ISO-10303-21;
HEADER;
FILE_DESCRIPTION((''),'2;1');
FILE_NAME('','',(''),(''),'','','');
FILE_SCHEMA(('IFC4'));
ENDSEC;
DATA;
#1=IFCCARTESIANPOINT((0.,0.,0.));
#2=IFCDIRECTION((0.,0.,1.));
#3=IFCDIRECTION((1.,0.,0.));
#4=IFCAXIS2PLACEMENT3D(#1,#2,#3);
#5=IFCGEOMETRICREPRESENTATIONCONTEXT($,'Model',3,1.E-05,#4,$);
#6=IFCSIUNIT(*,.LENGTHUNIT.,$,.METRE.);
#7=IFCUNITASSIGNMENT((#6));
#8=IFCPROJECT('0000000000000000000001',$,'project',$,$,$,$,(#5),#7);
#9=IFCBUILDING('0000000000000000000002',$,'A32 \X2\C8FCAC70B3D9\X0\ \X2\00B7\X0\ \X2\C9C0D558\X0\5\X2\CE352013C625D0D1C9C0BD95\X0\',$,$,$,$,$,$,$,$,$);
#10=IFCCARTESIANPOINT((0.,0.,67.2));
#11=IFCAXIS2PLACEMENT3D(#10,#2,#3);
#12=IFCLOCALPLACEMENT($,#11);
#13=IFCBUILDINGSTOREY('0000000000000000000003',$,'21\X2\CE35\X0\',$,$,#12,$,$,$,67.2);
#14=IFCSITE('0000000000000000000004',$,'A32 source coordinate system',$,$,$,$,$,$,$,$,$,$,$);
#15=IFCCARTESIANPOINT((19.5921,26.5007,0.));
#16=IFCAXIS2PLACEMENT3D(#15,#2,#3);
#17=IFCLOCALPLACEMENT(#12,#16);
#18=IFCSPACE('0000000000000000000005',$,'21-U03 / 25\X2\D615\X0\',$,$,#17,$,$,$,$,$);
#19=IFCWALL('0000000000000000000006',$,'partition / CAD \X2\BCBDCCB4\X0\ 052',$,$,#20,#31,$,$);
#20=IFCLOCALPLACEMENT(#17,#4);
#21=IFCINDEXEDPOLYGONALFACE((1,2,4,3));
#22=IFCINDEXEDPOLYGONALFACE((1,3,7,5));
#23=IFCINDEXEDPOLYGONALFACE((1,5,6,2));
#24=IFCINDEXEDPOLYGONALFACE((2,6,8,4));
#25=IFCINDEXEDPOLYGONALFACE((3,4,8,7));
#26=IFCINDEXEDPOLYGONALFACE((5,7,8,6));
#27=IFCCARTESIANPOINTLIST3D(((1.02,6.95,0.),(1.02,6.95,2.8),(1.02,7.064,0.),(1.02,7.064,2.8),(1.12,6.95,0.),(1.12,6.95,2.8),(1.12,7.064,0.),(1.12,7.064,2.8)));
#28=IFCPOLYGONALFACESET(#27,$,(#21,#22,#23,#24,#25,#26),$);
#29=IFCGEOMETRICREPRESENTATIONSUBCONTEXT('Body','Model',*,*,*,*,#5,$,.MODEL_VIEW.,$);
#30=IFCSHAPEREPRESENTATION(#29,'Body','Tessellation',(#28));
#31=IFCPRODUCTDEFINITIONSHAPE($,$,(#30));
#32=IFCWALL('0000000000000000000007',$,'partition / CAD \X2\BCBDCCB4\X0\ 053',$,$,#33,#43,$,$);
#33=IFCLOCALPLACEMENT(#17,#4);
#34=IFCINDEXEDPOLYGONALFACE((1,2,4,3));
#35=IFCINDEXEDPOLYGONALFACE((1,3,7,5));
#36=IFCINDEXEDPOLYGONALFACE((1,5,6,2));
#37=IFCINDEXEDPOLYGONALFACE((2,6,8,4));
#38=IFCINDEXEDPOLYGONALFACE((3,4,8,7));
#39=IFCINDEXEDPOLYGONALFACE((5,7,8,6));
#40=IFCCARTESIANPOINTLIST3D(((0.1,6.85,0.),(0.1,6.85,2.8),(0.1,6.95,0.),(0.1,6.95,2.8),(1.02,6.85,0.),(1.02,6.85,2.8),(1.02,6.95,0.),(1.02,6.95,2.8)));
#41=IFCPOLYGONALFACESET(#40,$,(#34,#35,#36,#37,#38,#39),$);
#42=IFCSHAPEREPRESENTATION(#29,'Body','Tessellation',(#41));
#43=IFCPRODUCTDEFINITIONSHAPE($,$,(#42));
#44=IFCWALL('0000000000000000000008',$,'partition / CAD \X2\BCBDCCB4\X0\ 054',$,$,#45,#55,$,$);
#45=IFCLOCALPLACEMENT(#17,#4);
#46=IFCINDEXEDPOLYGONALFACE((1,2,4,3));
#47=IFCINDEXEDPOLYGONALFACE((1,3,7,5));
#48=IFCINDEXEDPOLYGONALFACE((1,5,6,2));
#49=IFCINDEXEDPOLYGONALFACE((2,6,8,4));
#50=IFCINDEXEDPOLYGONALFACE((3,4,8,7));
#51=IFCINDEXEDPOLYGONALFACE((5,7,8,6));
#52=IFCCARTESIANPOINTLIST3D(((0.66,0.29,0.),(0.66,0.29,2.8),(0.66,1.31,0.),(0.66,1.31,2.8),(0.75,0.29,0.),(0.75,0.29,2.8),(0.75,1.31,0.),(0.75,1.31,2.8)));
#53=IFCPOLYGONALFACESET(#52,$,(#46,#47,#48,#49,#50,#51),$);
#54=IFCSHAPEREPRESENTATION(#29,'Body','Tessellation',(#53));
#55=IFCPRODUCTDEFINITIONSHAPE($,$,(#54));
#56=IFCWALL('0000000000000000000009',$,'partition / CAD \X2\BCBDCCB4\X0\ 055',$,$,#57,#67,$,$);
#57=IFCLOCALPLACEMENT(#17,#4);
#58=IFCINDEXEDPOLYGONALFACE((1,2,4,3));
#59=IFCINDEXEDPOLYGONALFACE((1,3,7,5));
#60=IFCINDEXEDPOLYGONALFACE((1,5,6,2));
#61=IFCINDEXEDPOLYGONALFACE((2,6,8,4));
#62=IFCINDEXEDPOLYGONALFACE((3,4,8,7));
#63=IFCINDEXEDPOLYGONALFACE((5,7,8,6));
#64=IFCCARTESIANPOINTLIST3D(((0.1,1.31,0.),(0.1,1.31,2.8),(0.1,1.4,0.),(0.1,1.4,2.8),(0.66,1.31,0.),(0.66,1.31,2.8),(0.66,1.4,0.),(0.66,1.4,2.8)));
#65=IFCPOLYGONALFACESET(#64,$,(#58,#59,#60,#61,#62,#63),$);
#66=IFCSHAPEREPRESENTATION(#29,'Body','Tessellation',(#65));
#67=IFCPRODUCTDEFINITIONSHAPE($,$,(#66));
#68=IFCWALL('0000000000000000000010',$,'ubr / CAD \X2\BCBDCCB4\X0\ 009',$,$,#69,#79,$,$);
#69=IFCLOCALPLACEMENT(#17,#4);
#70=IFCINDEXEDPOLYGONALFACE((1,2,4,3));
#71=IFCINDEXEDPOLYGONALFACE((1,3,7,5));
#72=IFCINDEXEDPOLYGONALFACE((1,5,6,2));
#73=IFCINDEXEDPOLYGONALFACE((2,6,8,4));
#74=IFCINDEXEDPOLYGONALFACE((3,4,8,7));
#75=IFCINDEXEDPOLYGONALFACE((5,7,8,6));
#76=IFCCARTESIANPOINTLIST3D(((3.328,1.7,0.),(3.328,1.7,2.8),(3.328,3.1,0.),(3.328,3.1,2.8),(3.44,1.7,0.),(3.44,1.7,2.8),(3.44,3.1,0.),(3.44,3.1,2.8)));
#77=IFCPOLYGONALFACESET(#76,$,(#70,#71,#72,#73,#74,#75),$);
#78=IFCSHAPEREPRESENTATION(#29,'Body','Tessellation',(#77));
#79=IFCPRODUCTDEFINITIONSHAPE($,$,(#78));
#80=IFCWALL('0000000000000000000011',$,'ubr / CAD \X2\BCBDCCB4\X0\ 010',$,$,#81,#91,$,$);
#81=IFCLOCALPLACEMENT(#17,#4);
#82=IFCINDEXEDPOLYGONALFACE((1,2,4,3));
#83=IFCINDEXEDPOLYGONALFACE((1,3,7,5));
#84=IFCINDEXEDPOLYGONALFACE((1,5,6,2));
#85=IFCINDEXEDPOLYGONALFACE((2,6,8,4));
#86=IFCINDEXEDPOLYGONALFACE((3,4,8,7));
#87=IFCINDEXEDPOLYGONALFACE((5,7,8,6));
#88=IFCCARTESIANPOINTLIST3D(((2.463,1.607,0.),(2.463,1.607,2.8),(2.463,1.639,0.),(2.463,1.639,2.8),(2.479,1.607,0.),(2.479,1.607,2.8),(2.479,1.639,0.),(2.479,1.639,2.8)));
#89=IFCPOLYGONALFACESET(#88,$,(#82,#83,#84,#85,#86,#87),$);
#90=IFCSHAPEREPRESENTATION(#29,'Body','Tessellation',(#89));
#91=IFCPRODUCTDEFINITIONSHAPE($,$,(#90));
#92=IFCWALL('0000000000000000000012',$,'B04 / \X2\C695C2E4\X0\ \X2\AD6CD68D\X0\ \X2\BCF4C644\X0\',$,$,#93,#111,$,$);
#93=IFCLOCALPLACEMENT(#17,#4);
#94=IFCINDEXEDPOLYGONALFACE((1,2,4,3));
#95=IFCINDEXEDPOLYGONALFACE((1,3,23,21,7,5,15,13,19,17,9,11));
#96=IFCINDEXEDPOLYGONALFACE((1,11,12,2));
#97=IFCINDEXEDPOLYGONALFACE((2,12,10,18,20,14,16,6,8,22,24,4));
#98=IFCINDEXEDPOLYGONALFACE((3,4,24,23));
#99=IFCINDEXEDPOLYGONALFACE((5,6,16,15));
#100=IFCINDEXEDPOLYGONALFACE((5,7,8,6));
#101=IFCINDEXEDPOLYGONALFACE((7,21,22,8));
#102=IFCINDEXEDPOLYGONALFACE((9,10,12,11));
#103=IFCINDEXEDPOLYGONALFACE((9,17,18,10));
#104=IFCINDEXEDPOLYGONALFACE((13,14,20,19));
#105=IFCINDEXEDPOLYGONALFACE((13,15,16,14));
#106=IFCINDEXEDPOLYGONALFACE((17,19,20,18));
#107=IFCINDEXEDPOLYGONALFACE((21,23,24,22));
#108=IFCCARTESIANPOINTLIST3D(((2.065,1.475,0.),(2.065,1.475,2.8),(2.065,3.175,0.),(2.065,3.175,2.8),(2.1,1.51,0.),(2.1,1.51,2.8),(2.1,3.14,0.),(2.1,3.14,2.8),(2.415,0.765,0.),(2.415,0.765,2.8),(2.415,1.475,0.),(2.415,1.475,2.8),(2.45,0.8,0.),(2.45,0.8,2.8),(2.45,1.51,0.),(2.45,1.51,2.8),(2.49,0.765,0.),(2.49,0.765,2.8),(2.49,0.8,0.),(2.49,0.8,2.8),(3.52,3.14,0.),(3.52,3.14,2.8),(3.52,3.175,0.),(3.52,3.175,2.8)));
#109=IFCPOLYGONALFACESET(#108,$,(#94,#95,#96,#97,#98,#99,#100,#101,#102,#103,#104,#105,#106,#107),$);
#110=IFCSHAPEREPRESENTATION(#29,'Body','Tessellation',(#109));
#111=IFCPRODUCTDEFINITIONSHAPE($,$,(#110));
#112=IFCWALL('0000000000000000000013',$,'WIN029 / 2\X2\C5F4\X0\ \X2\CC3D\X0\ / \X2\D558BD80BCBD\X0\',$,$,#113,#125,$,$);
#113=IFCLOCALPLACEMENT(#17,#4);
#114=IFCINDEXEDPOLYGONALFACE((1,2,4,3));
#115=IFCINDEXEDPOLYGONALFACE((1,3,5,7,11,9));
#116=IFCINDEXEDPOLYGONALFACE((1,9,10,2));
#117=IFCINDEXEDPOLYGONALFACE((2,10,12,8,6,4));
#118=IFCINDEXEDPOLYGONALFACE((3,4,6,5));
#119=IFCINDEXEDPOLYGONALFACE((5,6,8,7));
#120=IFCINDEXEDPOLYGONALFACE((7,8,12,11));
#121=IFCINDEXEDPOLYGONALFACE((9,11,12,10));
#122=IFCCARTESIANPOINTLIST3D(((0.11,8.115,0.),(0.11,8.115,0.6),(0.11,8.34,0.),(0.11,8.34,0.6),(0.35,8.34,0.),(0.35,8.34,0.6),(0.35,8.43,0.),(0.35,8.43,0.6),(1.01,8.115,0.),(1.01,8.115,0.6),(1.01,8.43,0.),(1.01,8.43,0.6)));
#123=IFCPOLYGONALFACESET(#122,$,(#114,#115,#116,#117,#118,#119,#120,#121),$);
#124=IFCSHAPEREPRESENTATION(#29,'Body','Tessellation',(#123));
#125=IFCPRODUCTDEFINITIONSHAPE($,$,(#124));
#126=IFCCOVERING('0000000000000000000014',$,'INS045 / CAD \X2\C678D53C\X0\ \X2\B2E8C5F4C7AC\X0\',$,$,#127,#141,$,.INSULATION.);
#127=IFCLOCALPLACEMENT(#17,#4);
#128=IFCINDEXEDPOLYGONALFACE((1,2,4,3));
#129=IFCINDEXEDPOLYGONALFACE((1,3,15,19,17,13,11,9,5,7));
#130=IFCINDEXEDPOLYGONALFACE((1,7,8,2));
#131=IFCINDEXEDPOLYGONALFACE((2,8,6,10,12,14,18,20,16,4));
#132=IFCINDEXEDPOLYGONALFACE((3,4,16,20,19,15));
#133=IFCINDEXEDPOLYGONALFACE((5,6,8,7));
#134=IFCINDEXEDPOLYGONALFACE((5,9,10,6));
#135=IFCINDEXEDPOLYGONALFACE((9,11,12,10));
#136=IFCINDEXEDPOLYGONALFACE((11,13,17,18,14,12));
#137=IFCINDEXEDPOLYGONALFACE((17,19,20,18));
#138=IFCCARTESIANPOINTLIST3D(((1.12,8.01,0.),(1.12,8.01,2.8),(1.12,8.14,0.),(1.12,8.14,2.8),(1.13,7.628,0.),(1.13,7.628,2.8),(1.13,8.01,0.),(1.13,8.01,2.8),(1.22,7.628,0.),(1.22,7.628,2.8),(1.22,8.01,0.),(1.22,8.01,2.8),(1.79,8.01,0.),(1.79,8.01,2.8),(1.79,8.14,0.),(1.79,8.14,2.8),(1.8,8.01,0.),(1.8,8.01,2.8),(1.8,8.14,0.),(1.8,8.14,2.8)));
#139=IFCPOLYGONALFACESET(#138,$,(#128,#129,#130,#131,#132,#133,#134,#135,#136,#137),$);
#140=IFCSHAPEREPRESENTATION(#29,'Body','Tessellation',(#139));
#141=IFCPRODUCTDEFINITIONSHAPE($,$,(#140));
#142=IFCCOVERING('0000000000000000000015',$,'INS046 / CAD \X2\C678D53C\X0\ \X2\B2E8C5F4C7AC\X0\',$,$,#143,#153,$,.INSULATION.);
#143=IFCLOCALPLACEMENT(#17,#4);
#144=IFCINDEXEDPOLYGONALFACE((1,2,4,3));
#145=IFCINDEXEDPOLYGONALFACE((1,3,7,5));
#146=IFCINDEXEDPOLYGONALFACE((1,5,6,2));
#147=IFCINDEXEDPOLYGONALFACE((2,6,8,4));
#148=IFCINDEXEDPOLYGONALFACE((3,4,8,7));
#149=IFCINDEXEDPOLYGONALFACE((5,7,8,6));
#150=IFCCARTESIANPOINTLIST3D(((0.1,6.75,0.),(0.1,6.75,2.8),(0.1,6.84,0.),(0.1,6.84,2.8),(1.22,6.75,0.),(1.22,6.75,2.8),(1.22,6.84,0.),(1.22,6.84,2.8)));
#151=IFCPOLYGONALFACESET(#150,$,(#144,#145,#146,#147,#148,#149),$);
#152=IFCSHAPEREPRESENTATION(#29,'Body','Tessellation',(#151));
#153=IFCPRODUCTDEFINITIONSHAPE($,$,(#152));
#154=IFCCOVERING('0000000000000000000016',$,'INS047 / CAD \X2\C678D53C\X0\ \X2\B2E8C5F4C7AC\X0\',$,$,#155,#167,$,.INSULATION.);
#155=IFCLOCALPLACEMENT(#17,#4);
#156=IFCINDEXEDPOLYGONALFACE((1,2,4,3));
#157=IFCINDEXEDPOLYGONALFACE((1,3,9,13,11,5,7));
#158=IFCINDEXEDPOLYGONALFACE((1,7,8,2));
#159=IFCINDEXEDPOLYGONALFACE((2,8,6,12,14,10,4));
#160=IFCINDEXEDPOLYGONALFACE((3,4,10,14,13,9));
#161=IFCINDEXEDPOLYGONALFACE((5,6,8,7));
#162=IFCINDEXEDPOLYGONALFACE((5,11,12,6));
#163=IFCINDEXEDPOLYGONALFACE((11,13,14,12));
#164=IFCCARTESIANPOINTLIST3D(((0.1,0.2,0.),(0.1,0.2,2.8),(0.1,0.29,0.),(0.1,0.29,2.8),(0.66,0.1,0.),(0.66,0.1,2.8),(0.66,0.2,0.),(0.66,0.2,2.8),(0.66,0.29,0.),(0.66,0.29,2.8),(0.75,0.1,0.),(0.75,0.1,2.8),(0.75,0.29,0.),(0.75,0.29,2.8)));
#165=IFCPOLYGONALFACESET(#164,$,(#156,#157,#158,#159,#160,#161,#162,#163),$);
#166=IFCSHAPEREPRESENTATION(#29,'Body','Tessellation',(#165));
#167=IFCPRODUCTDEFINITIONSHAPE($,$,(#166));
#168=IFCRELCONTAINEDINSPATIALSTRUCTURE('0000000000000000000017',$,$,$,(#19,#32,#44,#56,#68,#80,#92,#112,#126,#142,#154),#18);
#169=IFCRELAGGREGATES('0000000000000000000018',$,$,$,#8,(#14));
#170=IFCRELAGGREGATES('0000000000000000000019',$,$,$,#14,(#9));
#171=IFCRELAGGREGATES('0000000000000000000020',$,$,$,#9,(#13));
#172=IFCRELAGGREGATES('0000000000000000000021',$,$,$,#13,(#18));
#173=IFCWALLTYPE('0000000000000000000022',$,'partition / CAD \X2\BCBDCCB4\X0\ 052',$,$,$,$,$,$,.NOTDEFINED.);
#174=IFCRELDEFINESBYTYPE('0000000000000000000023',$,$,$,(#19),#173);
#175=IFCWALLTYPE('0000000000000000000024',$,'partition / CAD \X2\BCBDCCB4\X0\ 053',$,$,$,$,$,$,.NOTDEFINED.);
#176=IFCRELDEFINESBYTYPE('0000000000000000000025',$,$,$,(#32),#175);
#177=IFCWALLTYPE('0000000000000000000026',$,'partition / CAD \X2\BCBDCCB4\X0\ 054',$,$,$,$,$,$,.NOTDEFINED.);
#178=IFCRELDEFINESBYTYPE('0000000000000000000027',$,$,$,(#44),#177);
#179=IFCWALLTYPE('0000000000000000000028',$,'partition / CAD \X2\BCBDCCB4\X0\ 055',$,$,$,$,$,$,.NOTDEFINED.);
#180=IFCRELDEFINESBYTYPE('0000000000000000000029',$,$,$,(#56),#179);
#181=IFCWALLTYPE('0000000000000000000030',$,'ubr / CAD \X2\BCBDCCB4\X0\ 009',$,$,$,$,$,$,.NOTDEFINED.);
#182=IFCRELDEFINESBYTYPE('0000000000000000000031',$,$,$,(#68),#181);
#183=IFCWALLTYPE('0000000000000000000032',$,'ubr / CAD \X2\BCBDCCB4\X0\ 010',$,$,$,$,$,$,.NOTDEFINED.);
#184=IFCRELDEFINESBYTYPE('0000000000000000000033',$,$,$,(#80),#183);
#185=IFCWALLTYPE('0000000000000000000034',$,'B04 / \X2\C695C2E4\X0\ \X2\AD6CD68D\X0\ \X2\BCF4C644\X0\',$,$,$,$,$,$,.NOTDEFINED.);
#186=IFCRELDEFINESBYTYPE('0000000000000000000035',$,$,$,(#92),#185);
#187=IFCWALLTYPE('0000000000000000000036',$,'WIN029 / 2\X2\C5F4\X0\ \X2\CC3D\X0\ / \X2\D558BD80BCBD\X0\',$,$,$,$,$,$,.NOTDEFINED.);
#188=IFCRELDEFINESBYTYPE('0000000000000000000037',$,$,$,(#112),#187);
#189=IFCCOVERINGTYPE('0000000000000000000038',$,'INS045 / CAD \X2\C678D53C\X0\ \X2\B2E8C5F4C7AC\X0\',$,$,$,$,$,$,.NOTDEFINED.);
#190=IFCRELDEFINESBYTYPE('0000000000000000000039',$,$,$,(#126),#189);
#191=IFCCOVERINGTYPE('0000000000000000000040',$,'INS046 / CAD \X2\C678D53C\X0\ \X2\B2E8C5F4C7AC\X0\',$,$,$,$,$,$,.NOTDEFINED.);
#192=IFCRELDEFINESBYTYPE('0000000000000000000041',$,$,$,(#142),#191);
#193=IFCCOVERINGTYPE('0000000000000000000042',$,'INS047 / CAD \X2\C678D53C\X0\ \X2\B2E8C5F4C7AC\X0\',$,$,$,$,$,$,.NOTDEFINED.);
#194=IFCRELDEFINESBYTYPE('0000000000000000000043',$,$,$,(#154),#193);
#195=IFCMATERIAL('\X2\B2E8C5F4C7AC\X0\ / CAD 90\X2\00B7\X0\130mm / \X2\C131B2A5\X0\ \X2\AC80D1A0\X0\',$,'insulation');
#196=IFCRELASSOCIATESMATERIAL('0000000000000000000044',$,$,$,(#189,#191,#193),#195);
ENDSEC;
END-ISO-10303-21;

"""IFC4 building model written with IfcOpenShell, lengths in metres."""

from ifc_helpers import new_model, si_unit, frame, origin, origin_with_axes, place, context, subcontext, project, spatial, polyline, outline, extrude, source, transform, mapped, material, type_object, type_shapes, element, save


model = new_model("IFC4")

# Units and contexts
model_context = context("Model", 3, precision=1e-05, world=origin_with_axes())
body_context = subcontext(model_context, "Body", "Model", "MODEL_VIEW")
ifc_project = project(units=[si_unit("LENGTHUNIT", "METRE")], contexts=[model_context])

# Site, building, storey, space
storey_placement = place(None, frame((0.0, 0.0, 67.2), z_axis=(0.0, 0.0, 1.0), x_axis=(1.0, 0.0, 0.0)))
space_placement = place(storey_placement, frame((19.5921, 26.5007, 0.0), z_axis=(0.0, 0.0, 1.0), x_axis=(1.0, 0.0, 0.0)))
site = spatial("IfcSite", under=ifc_project, Name="A32 source coordinate system")
building = spatial("IfcBuilding", under=site, Name="A32 주거동 · 지하5층–옥탑지붕")
storey = spatial("IfcBuildingStorey", under=building, at=storey_placement, Name="21층", Elevation=67.2)
space = spatial("IfcSpace", under=storey, at=space_placement, Name="21-U03 / 25형")

# Walls
wall_type_1 = type_object("IfcWallType", Name="partition / CAD 벽체 052", PredefinedType="NOTDEFINED")
shared_shape_1 = source(origin(), body_context, "Body", "SweptSolid", [
    extrude(outline(polyline([(1.12, 6.95), (1.02, 6.95), (1.02, 7.064), (1.12, 7.064), (1.12, 6.95)])), origin(), (0.0, 0.0, 1.0), 2.8),
])
type_shapes(wall_type_1, [shared_shape_1])
wall_1_placement = place(space_placement, origin_with_axes())
element("IfcWall", 1, at=wall_1_placement, inside=space, type_object=wall_type_1, Name="partition / CAD 벽체 052", context=body_context, shape_type="MappedRepresentation", body=[
    mapped(shared_shape_1, transform((0.0, 0.0, 0.0), scale=1.0)),
])
wall_type_2 = type_object("IfcWallType", Name="partition / CAD 벽체 053", PredefinedType="NOTDEFINED")
shared_shape_2 = source(origin(), body_context, "Body", "SweptSolid", [
    extrude(outline(polyline([(1.02, 6.95), (1.02, 6.85), (0.1, 6.85), (0.1, 6.95), (1.02, 6.95)])), origin(), (0.0, 0.0, 1.0), 2.8),
])
type_shapes(wall_type_2, [shared_shape_2])
wall_2_placement = place(space_placement, origin_with_axes())
element("IfcWall", 2, at=wall_2_placement, inside=space, type_object=wall_type_2, Name="partition / CAD 벽체 053", context=body_context, shape_type="MappedRepresentation", body=[
    mapped(shared_shape_2, transform((0.0, 0.0, 0.0), scale=1.0)),
])
wall_type_3 = type_object("IfcWallType", Name="partition / CAD 벽체 054", PredefinedType="NOTDEFINED")
shared_shape_3 = source(origin(), body_context, "Body", "SweptSolid", [
    extrude(outline(polyline([(0.75, 0.29), (0.66, 0.29), (0.66, 1.31), (0.75, 1.31), (0.75, 0.29)])), origin(), (0.0, 0.0, 1.0), 2.8),
])
type_shapes(wall_type_3, [shared_shape_3])
wall_3_placement = place(space_placement, origin_with_axes())
element("IfcWall", 3, at=wall_3_placement, inside=space, type_object=wall_type_3, Name="partition / CAD 벽체 054", context=body_context, shape_type="MappedRepresentation", body=[
    mapped(shared_shape_3, transform((0.0, 0.0, 0.0), scale=1.0)),
])
wall_type_4 = type_object("IfcWallType", Name="partition / CAD 벽체 055", PredefinedType="NOTDEFINED")
shared_shape_4 = source(origin(), body_context, "Body", "SweptSolid", [
    extrude(outline(polyline([(0.66, 1.4), (0.66, 1.31), (0.1, 1.31), (0.1, 1.4), (0.66, 1.4)])), origin(), (0.0, 0.0, 1.0), 2.8),
])
type_shapes(wall_type_4, [shared_shape_4])
wall_4_placement = place(space_placement, origin_with_axes())
element("IfcWall", 4, at=wall_4_placement, inside=space, type_object=wall_type_4, Name="partition / CAD 벽체 055", context=body_context, shape_type="MappedRepresentation", body=[
    mapped(shared_shape_4, transform((0.0, 0.0, 0.0), scale=1.0)),
])
wall_type_5 = type_object("IfcWallType", Name="ubr / CAD 벽체 009", PredefinedType="NOTDEFINED")
shared_shape_5 = source(origin(), body_context, "Body", "SweptSolid", [
    extrude(outline(polyline([(3.328, 3.1), (3.44, 3.1), (3.44, 1.7), (3.328, 1.7), (3.328, 3.1)])), origin(), (0.0, 0.0, 1.0), 2.8),
])
type_shapes(wall_type_5, [shared_shape_5])
wall_5_placement = place(space_placement, origin_with_axes())
element("IfcWall", 5, at=wall_5_placement, inside=space, type_object=wall_type_5, Name="ubr / CAD 벽체 009", context=body_context, shape_type="MappedRepresentation", body=[
    mapped(shared_shape_5, transform((0.0, 0.0, 0.0), scale=1.0)),
])
wall_type_6 = type_object("IfcWallType", Name="ubr / CAD 벽체 010", PredefinedType="NOTDEFINED")
shared_shape_6 = source(origin(), body_context, "Body", "SweptSolid", [
    extrude(outline(polyline([(2.463, 1.607), (2.463, 1.639), (2.479, 1.639), (2.479, 1.607), (2.463, 1.607)])), origin(), (0.0, 0.0, 1.0), 2.8),
])
type_shapes(wall_type_6, [shared_shape_6])
wall_6_placement = place(space_placement, origin_with_axes())
element("IfcWall", 6, at=wall_6_placement, inside=space, type_object=wall_type_6, Name="ubr / CAD 벽체 010", context=body_context, shape_type="MappedRepresentation", body=[
    mapped(shared_shape_6, transform((0.0, 0.0, 0.0), scale=1.0)),
])
wall_type_7 = type_object("IfcWallType", Name="B04 / 욕실 구획 보완", PredefinedType="NOTDEFINED")
shared_shape_7 = source(origin(), body_context, "Body", "SweptSolid", [
    extrude(outline(polyline([(3.52, 3.175), (3.52, 3.14), (2.1, 3.14), (2.1, 1.51), (2.45, 1.51), (2.45, 0.8), (2.49, 0.8), (2.49, 0.765), (2.415, 0.765), (2.415, 1.475), (2.065, 1.475), (2.065, 3.175), (3.52, 3.175)])), origin(), (0.0, 0.0, 1.0), 2.8),
])
type_shapes(wall_type_7, [shared_shape_7])
wall_7_placement = place(space_placement, origin_with_axes())
element("IfcWall", 7, at=wall_7_placement, inside=space, type_object=wall_type_7, Name="B04 / 욕실 구획 보완", context=body_context, shape_type="MappedRepresentation", body=[
    mapped(shared_shape_7, transform((0.0, 0.0, 0.0), scale=1.0)),
])
wall_type_8 = type_object("IfcWallType", Name="WIN029 / 2열 창 / 하부벽", PredefinedType="NOTDEFINED")
shared_shape_8 = source(origin(), body_context, "Body", "SweptSolid", [
    extrude(outline(polyline([(1.01, 8.115), (0.11, 8.115), (0.11, 8.34), (0.35, 8.34), (0.35, 8.43), (1.01, 8.43), (1.01, 8.115)])), origin(), (0.0, 0.0, 1.0), 0.6),
])
type_shapes(wall_type_8, [shared_shape_8])
wall_8_placement = place(space_placement, origin_with_axes())
element("IfcWall", 8, at=wall_8_placement, inside=space, type_object=wall_type_8, Name="WIN029 / 2열 창 / 하부벽", context=body_context, shape_type="MappedRepresentation", body=[
    mapped(shared_shape_8, transform((0.0, 0.0, 0.0), scale=1.0)),
])

# Coverings
ifc_material = material(Name="단열재 / CAD 90·130mm / 성능 검토", Category="insulation")
covering_type_1 = type_object("IfcCoveringType", Name="INS045 / CAD 외피 단열재", PredefinedType="NOTDEFINED", material=ifc_material)
shared_shape_9 = source(origin(), body_context, "Body", "SweptSolid", [
    extrude(outline(polyline([(1.22, 8.01), (1.22, 7.628), (1.13, 7.628), (1.13, 8.01), (1.12, 8.01), (1.12, 8.14), (1.79, 8.14), (1.8, 8.14), (1.8, 8.01), (1.79, 8.01), (1.22, 8.01)])), origin(), (0.0, 0.0, 1.0), 2.8),
])
type_shapes(covering_type_1, [shared_shape_9])
covering_1_placement = place(space_placement, origin_with_axes())
element("IfcCovering", 9, at=covering_1_placement, inside=space, type_object=covering_type_1, Name="INS045 / CAD 외피 단열재", PredefinedType="INSULATION", context=body_context, shape_type="MappedRepresentation", body=[
    mapped(shared_shape_9, transform((0.0, 0.0, 0.0), scale=1.0)),
])
covering_type_2 = type_object("IfcCoveringType", Name="INS046 / CAD 외피 단열재", PredefinedType="NOTDEFINED", material=ifc_material)
shared_shape_10 = source(origin(), body_context, "Body", "SweptSolid", [
    extrude(outline(polyline([(0.1, 6.84), (1.22, 6.84), (1.22, 6.75), (0.1, 6.75), (0.1, 6.84)])), origin(), (0.0, 0.0, 1.0), 2.8),
])
type_shapes(covering_type_2, [shared_shape_10])
covering_2_placement = place(space_placement, origin_with_axes())
element("IfcCovering", 10, at=covering_2_placement, inside=space, type_object=covering_type_2, Name="INS046 / CAD 외피 단열재", PredefinedType="INSULATION", context=body_context, shape_type="MappedRepresentation", body=[
    mapped(shared_shape_10, transform((0.0, 0.0, 0.0), scale=1.0)),
])
covering_type_3 = type_object("IfcCoveringType", Name="INS047 / CAD 외피 단열재", PredefinedType="NOTDEFINED", material=ifc_material)
shared_shape_11 = source(origin(), body_context, "Body", "SweptSolid", [
    extrude(outline(polyline([(0.1, 0.2), (0.1, 0.29), (0.66, 0.29), (0.75, 0.29), (0.75, 0.1), (0.66, 0.1), (0.66, 0.2), (0.1, 0.2)])), origin(), (0.0, 0.0, 1.0), 2.8),
])
type_shapes(covering_type_3, [shared_shape_11])
covering_3_placement = place(space_placement, origin_with_axes())
element("IfcCovering", 11, at=covering_3_placement, inside=space, type_object=covering_type_3, Name="INS047 / CAD 외피 단열재", PredefinedType="INSULATION", context=body_context, shape_type="MappedRepresentation", body=[
    mapped(shared_shape_11, transform((0.0, 0.0, 0.0), scale=1.0)),
])

save(model, "model.ifc")
